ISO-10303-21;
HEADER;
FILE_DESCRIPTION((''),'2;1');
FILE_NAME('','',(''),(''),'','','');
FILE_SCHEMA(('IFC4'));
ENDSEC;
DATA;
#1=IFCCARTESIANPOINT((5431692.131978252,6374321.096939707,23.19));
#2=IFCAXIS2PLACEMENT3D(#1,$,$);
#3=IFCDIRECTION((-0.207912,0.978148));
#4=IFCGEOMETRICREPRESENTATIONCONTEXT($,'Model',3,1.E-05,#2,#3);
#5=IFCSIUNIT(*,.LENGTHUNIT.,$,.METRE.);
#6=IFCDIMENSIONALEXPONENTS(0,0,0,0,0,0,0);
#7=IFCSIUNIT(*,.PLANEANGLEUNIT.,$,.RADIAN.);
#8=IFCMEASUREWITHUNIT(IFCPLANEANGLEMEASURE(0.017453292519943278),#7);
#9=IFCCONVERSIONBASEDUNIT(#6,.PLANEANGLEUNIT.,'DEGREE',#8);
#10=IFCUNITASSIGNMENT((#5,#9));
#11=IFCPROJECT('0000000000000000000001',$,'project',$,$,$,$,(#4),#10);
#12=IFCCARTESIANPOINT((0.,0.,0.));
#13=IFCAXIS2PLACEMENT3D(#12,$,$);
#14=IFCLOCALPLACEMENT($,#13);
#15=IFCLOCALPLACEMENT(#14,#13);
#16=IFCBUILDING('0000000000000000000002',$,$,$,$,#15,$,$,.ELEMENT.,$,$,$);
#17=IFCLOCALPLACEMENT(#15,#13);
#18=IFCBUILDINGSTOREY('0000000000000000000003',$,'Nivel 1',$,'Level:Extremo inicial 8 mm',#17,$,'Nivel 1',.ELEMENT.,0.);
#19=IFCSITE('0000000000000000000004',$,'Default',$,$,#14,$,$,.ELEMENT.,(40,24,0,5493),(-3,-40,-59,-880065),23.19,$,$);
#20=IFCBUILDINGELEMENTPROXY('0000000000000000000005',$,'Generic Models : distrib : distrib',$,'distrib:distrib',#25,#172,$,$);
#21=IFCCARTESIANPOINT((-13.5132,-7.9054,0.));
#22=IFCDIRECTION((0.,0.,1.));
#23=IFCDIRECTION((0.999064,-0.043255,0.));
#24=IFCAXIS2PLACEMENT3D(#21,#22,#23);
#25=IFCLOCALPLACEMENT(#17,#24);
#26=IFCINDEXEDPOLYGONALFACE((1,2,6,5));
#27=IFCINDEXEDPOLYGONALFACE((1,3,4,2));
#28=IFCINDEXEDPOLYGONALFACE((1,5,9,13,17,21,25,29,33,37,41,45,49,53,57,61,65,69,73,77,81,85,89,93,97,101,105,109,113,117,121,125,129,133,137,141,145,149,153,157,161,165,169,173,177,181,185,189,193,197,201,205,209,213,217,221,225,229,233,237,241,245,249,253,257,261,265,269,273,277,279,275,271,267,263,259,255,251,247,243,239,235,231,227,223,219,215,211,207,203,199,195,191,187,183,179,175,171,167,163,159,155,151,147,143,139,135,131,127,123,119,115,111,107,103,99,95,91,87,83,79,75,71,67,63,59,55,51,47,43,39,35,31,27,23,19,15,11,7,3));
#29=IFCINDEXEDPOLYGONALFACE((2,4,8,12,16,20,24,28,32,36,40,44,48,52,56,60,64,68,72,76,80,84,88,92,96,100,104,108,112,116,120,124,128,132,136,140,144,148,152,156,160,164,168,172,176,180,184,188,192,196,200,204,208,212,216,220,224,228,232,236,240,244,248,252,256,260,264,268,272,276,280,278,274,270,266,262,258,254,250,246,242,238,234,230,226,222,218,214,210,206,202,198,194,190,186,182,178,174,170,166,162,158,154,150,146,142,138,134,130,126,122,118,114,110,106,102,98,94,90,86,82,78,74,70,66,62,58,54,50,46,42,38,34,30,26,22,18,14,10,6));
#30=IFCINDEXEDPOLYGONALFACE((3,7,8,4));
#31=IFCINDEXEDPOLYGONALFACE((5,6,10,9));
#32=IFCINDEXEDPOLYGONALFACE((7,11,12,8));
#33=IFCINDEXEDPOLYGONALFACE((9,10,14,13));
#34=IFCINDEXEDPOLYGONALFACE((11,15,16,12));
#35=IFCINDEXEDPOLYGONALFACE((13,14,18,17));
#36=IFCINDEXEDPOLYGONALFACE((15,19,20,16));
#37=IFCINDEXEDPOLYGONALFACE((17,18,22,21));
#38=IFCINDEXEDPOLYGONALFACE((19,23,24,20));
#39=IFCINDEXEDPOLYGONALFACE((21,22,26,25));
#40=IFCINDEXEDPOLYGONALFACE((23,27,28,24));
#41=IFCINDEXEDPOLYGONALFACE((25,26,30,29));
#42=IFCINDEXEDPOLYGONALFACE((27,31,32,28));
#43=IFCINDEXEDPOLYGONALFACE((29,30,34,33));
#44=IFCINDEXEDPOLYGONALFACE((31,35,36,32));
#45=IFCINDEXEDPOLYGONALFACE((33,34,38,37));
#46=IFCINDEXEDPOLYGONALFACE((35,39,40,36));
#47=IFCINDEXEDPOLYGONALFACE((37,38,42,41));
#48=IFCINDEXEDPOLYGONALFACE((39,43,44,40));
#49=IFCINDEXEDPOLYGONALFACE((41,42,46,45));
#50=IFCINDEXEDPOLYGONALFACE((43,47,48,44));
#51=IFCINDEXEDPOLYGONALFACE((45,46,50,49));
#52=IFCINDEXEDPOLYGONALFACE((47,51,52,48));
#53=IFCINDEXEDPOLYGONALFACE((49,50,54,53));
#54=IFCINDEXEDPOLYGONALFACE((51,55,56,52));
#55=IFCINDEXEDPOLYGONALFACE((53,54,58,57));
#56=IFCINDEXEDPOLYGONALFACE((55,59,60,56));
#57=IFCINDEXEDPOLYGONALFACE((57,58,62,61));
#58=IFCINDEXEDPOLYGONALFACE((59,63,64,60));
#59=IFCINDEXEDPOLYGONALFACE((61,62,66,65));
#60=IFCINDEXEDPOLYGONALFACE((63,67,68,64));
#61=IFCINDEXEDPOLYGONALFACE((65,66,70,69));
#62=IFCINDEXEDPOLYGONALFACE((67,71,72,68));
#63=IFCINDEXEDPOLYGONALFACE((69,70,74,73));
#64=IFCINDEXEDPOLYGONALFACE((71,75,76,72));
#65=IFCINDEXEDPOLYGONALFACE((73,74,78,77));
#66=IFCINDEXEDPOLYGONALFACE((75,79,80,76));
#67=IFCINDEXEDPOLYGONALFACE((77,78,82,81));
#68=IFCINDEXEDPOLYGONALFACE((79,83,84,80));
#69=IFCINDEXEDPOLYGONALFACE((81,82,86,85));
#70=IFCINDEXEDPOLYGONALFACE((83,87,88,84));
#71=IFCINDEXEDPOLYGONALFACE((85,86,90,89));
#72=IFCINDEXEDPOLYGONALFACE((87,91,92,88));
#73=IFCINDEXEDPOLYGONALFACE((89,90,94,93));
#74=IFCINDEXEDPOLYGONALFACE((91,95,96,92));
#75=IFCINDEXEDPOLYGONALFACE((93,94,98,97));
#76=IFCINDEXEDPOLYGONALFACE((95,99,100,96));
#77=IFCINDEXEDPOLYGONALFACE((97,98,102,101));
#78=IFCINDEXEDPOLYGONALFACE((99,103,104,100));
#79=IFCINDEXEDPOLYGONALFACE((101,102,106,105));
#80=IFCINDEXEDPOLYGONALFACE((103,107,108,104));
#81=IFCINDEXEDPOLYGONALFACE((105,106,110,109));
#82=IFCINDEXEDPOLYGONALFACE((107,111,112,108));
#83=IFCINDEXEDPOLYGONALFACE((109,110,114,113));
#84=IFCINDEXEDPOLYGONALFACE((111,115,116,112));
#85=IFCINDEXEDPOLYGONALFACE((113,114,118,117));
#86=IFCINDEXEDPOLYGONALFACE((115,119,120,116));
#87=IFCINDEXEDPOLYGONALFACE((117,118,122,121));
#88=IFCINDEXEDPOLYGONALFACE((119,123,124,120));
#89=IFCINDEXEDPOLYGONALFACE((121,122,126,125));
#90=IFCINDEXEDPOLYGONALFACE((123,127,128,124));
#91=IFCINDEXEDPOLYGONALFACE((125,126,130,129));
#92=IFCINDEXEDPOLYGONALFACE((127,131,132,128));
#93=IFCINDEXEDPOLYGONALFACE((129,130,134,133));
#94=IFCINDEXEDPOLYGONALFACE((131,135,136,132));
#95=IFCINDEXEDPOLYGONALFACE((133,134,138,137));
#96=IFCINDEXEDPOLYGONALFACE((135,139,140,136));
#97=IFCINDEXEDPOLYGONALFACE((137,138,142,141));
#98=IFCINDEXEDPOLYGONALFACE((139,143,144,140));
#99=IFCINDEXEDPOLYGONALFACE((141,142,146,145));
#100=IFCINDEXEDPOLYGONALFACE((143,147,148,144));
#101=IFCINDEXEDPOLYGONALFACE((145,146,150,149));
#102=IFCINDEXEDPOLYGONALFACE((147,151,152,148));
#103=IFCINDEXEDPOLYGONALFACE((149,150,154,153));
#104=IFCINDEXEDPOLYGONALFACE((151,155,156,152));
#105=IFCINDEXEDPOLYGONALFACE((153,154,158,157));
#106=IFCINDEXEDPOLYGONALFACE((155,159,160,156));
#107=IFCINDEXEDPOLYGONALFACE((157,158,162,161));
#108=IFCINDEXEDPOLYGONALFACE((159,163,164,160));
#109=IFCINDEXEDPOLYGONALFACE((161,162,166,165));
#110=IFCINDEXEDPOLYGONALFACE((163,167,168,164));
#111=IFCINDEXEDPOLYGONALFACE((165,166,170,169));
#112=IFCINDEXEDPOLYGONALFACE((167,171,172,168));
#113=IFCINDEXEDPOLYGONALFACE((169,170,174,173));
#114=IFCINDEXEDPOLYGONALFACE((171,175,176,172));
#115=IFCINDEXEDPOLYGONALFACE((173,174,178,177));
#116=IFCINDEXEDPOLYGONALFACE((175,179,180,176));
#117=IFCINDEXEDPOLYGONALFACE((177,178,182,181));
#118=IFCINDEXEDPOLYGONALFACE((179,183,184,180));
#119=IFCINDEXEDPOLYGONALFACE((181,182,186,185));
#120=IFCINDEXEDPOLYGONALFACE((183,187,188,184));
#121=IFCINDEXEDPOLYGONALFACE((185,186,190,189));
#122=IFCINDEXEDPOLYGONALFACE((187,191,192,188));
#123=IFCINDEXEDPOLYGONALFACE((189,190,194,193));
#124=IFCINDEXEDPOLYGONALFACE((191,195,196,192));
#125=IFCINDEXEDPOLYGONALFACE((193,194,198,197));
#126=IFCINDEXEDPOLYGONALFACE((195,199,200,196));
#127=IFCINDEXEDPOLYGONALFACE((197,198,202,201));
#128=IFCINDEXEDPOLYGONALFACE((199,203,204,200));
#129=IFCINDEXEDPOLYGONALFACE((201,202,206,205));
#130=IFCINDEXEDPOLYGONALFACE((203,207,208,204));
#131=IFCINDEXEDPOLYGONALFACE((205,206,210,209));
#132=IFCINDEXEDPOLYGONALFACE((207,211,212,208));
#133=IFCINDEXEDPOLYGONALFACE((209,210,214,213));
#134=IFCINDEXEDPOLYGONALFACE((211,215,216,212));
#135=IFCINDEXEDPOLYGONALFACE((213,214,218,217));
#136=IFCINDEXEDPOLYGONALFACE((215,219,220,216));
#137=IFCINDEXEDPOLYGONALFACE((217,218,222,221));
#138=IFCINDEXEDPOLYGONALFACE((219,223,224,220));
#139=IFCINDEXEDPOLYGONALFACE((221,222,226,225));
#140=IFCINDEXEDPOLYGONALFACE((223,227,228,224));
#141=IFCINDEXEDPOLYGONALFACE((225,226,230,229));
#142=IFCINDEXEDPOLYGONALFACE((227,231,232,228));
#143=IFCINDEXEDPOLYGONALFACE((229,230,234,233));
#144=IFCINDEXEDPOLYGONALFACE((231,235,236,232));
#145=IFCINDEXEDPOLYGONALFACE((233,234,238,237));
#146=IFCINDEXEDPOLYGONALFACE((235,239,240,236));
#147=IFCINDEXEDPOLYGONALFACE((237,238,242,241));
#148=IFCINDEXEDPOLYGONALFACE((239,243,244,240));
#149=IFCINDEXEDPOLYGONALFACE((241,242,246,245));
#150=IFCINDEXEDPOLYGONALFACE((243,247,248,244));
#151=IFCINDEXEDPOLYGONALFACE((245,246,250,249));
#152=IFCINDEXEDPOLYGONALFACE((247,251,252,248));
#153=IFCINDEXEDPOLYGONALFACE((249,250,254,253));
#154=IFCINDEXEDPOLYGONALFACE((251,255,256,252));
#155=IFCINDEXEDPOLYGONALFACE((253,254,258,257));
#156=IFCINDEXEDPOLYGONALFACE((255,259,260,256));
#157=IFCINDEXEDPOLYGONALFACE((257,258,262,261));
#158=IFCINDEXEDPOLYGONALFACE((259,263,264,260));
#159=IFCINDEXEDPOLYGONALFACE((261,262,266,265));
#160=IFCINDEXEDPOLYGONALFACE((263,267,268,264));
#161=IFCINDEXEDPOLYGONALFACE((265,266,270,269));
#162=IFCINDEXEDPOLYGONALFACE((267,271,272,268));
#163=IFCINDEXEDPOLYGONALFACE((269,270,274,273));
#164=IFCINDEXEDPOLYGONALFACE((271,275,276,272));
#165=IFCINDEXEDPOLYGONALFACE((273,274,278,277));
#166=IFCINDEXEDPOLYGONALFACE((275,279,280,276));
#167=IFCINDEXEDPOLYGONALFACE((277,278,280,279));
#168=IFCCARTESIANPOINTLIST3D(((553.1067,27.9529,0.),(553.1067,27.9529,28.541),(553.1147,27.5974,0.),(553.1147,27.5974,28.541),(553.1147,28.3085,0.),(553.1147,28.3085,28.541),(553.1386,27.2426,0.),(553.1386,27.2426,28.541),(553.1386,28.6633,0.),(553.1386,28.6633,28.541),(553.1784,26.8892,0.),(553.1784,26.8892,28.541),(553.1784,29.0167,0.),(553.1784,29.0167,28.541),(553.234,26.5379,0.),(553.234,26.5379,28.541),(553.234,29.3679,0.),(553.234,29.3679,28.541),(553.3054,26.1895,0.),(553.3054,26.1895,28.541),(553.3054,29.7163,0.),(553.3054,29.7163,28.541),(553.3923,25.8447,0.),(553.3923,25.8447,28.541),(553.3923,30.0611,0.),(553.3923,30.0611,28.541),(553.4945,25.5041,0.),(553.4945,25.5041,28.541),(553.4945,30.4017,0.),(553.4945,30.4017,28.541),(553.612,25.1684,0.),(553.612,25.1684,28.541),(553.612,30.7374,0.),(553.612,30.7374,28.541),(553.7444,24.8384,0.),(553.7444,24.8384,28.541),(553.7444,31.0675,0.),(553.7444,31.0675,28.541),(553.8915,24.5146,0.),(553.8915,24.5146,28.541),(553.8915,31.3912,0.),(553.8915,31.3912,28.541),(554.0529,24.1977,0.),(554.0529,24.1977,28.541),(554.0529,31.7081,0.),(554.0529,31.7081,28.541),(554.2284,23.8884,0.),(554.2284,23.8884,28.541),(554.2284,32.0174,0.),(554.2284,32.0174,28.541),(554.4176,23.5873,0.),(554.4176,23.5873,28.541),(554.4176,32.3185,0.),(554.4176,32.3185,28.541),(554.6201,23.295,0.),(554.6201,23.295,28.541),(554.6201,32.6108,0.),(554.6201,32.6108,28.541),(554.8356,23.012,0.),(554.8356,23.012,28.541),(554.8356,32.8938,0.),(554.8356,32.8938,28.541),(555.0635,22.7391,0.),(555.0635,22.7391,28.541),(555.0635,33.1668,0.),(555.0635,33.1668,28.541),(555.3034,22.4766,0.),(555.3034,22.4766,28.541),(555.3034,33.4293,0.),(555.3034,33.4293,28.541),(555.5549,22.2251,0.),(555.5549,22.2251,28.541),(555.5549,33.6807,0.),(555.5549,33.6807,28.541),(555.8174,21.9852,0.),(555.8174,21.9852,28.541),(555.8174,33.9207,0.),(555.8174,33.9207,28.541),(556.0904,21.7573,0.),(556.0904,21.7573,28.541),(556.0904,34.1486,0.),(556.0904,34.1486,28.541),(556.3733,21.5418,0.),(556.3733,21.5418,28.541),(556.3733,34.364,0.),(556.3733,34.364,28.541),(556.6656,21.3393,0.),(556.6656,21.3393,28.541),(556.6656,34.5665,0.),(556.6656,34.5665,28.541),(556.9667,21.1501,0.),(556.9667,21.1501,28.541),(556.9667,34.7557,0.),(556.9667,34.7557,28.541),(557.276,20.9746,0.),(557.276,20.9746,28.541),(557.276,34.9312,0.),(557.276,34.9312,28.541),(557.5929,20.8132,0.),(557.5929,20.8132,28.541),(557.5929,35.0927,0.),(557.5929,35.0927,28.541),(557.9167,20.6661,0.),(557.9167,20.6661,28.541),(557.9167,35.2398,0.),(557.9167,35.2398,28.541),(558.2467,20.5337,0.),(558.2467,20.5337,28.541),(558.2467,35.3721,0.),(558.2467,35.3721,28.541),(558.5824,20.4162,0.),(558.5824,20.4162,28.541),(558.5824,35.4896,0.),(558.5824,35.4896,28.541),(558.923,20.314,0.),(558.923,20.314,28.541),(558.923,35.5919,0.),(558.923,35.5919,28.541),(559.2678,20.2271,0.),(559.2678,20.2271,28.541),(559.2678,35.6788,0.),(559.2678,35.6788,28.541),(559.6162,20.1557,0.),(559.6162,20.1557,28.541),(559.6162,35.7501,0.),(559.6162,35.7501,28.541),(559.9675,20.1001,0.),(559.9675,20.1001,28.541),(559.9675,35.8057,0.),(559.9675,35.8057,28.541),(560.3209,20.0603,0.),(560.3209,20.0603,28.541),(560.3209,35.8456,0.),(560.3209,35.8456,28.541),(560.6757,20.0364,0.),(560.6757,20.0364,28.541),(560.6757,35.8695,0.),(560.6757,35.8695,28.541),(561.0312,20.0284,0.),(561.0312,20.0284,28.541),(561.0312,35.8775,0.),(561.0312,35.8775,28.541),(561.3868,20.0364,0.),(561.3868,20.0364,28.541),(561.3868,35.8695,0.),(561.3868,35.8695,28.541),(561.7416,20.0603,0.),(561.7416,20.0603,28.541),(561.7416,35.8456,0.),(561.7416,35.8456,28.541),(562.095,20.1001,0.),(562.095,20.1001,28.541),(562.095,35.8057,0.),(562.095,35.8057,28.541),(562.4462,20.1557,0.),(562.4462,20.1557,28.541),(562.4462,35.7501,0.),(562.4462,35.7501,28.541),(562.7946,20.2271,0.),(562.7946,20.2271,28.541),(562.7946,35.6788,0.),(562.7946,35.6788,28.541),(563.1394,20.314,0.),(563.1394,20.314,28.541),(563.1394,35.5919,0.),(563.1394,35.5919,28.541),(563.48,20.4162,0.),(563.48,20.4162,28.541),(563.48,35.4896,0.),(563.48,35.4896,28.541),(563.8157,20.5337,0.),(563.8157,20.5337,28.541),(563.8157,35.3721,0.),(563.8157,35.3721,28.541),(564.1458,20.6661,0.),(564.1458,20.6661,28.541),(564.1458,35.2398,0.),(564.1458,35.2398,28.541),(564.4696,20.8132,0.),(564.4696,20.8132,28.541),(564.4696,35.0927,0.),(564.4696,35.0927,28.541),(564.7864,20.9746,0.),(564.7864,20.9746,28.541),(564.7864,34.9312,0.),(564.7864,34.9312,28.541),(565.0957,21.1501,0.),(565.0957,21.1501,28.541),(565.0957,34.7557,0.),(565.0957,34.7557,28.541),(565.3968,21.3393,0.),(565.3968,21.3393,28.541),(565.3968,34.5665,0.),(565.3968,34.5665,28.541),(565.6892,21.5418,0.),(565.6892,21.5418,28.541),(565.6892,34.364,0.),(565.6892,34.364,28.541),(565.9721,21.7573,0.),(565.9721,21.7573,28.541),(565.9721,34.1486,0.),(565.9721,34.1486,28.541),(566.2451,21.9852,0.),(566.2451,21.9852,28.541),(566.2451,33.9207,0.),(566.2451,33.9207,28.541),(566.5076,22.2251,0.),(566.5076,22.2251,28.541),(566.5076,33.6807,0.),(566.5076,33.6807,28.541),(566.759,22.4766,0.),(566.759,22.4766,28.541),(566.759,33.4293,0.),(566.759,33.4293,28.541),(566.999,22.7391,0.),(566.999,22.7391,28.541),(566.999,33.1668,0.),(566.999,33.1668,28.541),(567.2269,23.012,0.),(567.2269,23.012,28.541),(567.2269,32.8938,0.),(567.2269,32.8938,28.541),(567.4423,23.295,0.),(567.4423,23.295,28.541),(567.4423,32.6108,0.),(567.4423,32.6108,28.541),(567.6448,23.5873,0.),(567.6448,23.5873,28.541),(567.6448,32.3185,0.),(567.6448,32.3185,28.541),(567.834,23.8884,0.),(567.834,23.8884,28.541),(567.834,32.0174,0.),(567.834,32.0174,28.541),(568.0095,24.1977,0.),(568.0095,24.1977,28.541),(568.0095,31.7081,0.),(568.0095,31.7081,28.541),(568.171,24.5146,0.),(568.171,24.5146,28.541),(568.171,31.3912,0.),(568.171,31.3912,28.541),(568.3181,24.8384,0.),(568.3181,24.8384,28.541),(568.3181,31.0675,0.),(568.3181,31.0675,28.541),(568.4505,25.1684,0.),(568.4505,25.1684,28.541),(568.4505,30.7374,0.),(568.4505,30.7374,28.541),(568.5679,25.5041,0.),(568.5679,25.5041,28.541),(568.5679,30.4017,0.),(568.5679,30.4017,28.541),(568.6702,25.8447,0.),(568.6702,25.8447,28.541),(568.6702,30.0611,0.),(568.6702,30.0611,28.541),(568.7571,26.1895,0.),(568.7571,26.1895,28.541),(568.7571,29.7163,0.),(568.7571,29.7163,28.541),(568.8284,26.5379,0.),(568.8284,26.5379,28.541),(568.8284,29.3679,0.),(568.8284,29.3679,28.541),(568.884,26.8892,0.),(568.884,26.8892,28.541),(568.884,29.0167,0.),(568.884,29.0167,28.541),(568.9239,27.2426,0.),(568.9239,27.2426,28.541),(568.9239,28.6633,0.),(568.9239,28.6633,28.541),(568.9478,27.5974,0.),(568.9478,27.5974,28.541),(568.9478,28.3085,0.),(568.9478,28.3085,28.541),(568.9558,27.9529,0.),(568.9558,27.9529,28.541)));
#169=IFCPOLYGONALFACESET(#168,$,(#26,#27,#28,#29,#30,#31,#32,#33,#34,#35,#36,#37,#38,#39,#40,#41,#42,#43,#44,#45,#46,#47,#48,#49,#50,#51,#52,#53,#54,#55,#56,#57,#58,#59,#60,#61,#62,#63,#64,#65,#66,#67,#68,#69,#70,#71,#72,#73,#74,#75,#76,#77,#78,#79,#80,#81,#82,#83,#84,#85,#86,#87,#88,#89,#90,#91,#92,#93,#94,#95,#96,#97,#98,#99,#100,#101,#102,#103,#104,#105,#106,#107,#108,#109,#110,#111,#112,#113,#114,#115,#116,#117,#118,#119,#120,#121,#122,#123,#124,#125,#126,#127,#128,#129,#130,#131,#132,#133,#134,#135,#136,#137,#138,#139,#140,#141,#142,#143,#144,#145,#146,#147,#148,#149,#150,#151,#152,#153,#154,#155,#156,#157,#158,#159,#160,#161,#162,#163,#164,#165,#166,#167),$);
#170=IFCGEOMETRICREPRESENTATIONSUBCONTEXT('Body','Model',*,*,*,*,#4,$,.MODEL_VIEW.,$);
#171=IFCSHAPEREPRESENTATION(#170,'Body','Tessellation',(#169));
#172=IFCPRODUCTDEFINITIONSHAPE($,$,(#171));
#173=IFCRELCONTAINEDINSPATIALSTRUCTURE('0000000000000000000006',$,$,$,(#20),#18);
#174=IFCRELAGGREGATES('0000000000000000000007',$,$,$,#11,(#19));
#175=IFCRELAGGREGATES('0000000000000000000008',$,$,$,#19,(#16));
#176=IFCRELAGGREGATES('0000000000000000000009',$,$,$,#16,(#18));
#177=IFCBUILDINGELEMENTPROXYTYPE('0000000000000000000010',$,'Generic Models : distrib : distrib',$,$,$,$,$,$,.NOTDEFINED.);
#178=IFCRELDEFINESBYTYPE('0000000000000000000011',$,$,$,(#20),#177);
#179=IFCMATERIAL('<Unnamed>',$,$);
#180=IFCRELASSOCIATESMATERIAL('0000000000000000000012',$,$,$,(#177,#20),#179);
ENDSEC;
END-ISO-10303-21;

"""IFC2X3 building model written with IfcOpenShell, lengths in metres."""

from ifc_helpers import new_model, entity, si_unit, converted_unit, direction, frame, frame_2d, origin, place, context, subcontext, project, spatial, circle, extrude, source, transform, mapped, material, type_object, type_shapes, element, save


model = new_model("IFC2X3")

# Units and contexts
model_context = context("Model", 3, precision=1e-05, world=frame((5431692.131978252, 6374321.096939707, 23.19)), true_north=direction((-0.207912, 0.978148)))
body_context = subcontext(model_context, "Body", "Model", "MODEL_VIEW")
ifc_project = project(units=[si_unit("LENGTHUNIT", "METRE"), converted_unit("PLANEANGLEUNIT", "DEGREE", entity("IfcPlaneAngleMeasure", 0.017453292519943278), si_unit("PLANEANGLEUNIT", "RADIAN"), dimensions=[0, 0, 0, 0, 0, 0, 0])], contexts=[model_context])

# Site, building, storey
site_placement = place(None, origin())
site = spatial("IfcSite", under=ifc_project, at=site_placement, Name="Default", CompositionType="ELEMENT", RefLatitude=(40, 24, 0, 5493), RefLongitude=(-3, -40, -59, -880065), RefElevation=23.19)
building_placement = place(site_placement, origin())
building = spatial("IfcBuilding", under=site, at=building_placement, CompositionType="ELEMENT")
storey_placement = place(building_placement, origin())
storey = spatial("IfcBuildingStorey", under=building, at=storey_placement, Name="Nivel 1", ObjectType="Level:Extremo inicial 8 mm", LongName="Nivel 1", CompositionType="ELEMENT", Elevation=0.0)

# Building element proxy
ifc_material_1 = material(Name="<Unnamed>")
building_element_proxy_type_1 = type_object("IfcBuildingElementProxyType", Name="Generic Models : distrib : distrib", PredefinedType="NOTDEFINED", material=ifc_material_1)
shared_shape_1 = source(origin(), body_context, "Body", "SweptSolid", [
    extrude(circle(Radius=7.9245, at=frame_2d((0.0, 0.0), x_axis=(1.0, 0.0))), frame((561.0312, 27.9529, 0.0)), (0.0, 0.0, 1.0), 28.541),
])
type_shapes(building_element_proxy_type_1, [shared_shape_1])
proxy_1_placement = place(storey_placement, frame((-13.5132, -7.9054, 0.0), z_axis=(0.0, 0.0, 1.0), x_axis=(0.999064, -0.043255, 0.0)))
element("IfcBuildingElementProxy", 1, at=proxy_1_placement, inside=storey, type_object=building_element_proxy_type_1, material=ifc_material_1, Name="Generic Models : distrib : distrib", ObjectType="distrib:distrib", context=body_context, shape_type="MappedRepresentation", body=[
    mapped(shared_shape_1, transform((0.0, 0.0, 0.0), scale=1.0)),
])

save(model, "model.ifc")
